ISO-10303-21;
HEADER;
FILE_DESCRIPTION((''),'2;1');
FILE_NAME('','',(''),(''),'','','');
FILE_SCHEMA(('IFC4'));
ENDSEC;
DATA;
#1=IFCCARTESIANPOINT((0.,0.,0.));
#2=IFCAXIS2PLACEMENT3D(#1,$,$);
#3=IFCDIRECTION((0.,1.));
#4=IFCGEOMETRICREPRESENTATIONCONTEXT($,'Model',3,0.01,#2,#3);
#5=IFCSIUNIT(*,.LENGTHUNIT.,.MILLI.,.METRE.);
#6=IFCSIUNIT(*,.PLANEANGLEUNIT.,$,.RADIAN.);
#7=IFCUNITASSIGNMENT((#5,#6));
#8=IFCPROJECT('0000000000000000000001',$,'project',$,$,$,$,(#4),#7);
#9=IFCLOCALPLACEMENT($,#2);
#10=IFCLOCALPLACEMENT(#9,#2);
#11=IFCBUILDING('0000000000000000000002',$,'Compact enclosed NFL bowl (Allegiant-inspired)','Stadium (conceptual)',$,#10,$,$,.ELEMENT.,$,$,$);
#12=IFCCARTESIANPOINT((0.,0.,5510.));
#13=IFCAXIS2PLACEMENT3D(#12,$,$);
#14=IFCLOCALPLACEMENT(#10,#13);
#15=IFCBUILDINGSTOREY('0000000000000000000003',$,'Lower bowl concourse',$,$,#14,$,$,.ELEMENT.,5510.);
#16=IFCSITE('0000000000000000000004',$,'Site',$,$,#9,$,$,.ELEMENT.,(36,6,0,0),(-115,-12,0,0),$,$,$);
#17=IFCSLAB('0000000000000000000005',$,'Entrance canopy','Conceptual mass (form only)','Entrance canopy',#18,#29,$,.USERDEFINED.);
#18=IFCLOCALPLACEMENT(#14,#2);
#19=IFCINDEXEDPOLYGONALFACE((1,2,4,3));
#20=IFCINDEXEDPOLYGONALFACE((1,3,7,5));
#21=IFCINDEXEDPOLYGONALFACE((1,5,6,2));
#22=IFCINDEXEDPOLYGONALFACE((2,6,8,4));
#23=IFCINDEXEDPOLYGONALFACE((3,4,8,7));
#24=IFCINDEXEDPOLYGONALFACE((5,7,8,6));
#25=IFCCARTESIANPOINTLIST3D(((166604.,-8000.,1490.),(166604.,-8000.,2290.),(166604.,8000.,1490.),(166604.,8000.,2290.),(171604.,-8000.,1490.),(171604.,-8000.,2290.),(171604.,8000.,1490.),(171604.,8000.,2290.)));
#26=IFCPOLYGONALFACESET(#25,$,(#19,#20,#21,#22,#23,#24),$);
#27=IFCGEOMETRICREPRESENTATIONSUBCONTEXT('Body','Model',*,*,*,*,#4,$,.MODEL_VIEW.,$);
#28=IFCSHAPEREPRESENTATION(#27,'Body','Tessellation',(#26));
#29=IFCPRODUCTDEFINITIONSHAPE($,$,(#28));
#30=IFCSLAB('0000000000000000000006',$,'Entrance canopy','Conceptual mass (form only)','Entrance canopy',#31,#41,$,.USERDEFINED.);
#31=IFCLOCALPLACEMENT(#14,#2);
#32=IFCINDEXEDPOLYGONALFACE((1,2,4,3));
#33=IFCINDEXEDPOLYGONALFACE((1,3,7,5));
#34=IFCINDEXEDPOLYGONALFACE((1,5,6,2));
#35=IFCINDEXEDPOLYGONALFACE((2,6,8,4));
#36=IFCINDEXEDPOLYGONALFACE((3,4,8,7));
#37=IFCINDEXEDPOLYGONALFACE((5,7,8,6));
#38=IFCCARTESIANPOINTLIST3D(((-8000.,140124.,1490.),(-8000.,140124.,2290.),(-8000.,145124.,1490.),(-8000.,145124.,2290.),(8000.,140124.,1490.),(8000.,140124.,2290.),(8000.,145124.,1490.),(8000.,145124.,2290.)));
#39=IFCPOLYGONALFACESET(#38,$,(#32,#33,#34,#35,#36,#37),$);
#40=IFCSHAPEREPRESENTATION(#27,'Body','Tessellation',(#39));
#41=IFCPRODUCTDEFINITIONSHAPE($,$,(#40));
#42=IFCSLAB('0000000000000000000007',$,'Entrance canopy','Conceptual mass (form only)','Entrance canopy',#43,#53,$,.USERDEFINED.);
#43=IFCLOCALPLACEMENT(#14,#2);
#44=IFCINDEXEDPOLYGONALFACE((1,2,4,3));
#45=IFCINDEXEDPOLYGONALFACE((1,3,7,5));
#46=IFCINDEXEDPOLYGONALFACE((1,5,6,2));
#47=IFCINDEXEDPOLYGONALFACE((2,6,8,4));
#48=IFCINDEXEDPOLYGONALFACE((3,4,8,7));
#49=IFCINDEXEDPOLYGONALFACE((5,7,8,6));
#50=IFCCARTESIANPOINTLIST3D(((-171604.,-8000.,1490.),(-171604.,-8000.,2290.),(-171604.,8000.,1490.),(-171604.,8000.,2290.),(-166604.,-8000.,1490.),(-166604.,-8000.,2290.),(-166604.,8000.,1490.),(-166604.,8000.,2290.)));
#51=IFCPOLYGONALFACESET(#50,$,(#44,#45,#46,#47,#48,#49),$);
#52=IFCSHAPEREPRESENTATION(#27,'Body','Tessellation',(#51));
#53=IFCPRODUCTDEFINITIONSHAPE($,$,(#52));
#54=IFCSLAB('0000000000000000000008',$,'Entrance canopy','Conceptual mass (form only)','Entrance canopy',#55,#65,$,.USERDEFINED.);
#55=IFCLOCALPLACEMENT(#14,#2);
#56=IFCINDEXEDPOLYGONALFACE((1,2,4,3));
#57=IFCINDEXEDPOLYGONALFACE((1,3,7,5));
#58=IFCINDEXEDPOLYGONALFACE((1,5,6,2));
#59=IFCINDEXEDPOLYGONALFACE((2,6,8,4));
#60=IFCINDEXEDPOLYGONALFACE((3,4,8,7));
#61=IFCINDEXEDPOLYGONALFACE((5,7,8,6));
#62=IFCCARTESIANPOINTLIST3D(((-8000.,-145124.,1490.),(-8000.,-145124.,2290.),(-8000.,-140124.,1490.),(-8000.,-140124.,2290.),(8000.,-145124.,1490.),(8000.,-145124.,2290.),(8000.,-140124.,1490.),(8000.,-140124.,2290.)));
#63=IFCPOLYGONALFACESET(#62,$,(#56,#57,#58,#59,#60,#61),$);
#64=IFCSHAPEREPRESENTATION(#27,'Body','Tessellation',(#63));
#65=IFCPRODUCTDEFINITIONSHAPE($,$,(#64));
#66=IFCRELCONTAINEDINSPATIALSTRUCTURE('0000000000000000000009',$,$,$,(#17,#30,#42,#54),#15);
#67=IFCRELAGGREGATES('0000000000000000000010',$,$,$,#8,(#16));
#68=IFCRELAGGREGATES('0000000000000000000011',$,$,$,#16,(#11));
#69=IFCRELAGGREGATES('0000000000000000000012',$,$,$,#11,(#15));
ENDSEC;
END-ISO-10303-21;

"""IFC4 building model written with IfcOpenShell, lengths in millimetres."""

from ifc_helpers import new_model, si_unit, direction, frame, origin, place, context, subcontext, project, spatial, line, indexed_curve, outline, extrude, element, save


model = new_model("IFC4")

# Units and contexts
model_context = context("Model", 3, precision=0.01, world=origin(), true_north=direction((0.0, 1.0)))
body_context = subcontext(model_context, "Body", "Model", "MODEL_VIEW")
ifc_project = project(units=[si_unit("LENGTHUNIT", "METRE", prefix="MILLI"), si_unit("PLANEANGLEUNIT", "RADIAN")], contexts=[model_context])

# Site, building, storey
site_placement = place(None, origin())
site = spatial("IfcSite", under=ifc_project, at=site_placement, Name="Site", CompositionType="ELEMENT", RefLatitude=(36, 6, 0, 0), RefLongitude=(-115, -12, 0, 0))
building_placement = place(site_placement, origin())
building = spatial("IfcBuilding", under=site, at=building_placement, Name="Compact enclosed NFL bowl (Allegiant-inspired)", Description="Stadium (conceptual)", CompositionType="ELEMENT")
storey_placement = place(building_placement, frame((0.0, 0.0, 5510.0)))
storey = spatial("IfcBuildingStorey", under=building, at=storey_placement, Name="Lower bowl concourse", CompositionType="ELEMENT", Elevation=5510.0)

# Slabs
placement = place(storey_placement, frame((0.0, 0.0, -5510.0)))
element("IfcSlab", 1, at=placement, inside=storey, Name="Entrance canopy", Description="Conceptual mass (form only)", ObjectType="Entrance canopy", PredefinedType="USERDEFINED", context=body_context, shape_type="SweptSolid", body=[
    extrude(outline(indexed_curve([(166604.0, -8000.0), (166604.0, 8000.0), (171604.0, 8000.0), (171604.0, -8000.0)], segments=[line(1, 2), line(2, 3), line(3, 4), line(4, 1)], self_intersect=False)), frame((0.0, 0.0, 7000.0)), (0.0, 0.0, 1.0), 800.0),
])
element("IfcSlab", 2, at=placement, inside=storey, Name="Entrance canopy", Description="Conceptual mass (form only)", ObjectType="Entrance canopy", PredefinedType="USERDEFINED", context=body_context, shape_type="SweptSolid", body=[
    extrude(outline(indexed_curve([(8000.0, 140124.0), (-8000.0, 140124.0), (-8000.0, 145124.0), (8000.0, 145124.0)], segments=[line(1, 2), line(2, 3), line(3, 4), line(4, 1)], self_intersect=False)), frame((0.0, 0.0, 7000.0)), (0.0, 0.0, 1.0), 800.0),
])
element("IfcSlab", 3, at=placement, inside=storey, Name="Entrance canopy", Description="Conceptual mass (form only)", ObjectType="Entrance canopy", PredefinedType="USERDEFINED", context=body_context, shape_type="SweptSolid", body=[
    extrude(outline(indexed_curve([(-166604.0, 8000.0), (-166604.0, -8000.0), (-171604.0, -8000.0), (-171604.0, 8000.0)], segments=[line(1, 2), line(2, 3), line(3, 4), line(4, 1)], self_intersect=False)), frame((0.0, 0.0, 7000.0)), (0.0, 0.0, 1.0), 800.0),
])
element("IfcSlab", 4, at=placement, inside=storey, Name="Entrance canopy", Description="Conceptual mass (form only)", ObjectType="Entrance canopy", PredefinedType="USERDEFINED", context=body_context, shape_type="SweptSolid", body=[
    extrude(outline(indexed_curve([(-8000.0, -140124.0), (8000.0, -140124.0), (8000.0, -145124.0), (-8000.0, -145124.0)], segments=[line(1, 2), line(2, 3), line(3, 4), line(4, 1)], self_intersect=False)), frame((0.0, 0.0, 7000.0)), (0.0, 0.0, 1.0), 800.0),
])

save(model, "model.ifc")
